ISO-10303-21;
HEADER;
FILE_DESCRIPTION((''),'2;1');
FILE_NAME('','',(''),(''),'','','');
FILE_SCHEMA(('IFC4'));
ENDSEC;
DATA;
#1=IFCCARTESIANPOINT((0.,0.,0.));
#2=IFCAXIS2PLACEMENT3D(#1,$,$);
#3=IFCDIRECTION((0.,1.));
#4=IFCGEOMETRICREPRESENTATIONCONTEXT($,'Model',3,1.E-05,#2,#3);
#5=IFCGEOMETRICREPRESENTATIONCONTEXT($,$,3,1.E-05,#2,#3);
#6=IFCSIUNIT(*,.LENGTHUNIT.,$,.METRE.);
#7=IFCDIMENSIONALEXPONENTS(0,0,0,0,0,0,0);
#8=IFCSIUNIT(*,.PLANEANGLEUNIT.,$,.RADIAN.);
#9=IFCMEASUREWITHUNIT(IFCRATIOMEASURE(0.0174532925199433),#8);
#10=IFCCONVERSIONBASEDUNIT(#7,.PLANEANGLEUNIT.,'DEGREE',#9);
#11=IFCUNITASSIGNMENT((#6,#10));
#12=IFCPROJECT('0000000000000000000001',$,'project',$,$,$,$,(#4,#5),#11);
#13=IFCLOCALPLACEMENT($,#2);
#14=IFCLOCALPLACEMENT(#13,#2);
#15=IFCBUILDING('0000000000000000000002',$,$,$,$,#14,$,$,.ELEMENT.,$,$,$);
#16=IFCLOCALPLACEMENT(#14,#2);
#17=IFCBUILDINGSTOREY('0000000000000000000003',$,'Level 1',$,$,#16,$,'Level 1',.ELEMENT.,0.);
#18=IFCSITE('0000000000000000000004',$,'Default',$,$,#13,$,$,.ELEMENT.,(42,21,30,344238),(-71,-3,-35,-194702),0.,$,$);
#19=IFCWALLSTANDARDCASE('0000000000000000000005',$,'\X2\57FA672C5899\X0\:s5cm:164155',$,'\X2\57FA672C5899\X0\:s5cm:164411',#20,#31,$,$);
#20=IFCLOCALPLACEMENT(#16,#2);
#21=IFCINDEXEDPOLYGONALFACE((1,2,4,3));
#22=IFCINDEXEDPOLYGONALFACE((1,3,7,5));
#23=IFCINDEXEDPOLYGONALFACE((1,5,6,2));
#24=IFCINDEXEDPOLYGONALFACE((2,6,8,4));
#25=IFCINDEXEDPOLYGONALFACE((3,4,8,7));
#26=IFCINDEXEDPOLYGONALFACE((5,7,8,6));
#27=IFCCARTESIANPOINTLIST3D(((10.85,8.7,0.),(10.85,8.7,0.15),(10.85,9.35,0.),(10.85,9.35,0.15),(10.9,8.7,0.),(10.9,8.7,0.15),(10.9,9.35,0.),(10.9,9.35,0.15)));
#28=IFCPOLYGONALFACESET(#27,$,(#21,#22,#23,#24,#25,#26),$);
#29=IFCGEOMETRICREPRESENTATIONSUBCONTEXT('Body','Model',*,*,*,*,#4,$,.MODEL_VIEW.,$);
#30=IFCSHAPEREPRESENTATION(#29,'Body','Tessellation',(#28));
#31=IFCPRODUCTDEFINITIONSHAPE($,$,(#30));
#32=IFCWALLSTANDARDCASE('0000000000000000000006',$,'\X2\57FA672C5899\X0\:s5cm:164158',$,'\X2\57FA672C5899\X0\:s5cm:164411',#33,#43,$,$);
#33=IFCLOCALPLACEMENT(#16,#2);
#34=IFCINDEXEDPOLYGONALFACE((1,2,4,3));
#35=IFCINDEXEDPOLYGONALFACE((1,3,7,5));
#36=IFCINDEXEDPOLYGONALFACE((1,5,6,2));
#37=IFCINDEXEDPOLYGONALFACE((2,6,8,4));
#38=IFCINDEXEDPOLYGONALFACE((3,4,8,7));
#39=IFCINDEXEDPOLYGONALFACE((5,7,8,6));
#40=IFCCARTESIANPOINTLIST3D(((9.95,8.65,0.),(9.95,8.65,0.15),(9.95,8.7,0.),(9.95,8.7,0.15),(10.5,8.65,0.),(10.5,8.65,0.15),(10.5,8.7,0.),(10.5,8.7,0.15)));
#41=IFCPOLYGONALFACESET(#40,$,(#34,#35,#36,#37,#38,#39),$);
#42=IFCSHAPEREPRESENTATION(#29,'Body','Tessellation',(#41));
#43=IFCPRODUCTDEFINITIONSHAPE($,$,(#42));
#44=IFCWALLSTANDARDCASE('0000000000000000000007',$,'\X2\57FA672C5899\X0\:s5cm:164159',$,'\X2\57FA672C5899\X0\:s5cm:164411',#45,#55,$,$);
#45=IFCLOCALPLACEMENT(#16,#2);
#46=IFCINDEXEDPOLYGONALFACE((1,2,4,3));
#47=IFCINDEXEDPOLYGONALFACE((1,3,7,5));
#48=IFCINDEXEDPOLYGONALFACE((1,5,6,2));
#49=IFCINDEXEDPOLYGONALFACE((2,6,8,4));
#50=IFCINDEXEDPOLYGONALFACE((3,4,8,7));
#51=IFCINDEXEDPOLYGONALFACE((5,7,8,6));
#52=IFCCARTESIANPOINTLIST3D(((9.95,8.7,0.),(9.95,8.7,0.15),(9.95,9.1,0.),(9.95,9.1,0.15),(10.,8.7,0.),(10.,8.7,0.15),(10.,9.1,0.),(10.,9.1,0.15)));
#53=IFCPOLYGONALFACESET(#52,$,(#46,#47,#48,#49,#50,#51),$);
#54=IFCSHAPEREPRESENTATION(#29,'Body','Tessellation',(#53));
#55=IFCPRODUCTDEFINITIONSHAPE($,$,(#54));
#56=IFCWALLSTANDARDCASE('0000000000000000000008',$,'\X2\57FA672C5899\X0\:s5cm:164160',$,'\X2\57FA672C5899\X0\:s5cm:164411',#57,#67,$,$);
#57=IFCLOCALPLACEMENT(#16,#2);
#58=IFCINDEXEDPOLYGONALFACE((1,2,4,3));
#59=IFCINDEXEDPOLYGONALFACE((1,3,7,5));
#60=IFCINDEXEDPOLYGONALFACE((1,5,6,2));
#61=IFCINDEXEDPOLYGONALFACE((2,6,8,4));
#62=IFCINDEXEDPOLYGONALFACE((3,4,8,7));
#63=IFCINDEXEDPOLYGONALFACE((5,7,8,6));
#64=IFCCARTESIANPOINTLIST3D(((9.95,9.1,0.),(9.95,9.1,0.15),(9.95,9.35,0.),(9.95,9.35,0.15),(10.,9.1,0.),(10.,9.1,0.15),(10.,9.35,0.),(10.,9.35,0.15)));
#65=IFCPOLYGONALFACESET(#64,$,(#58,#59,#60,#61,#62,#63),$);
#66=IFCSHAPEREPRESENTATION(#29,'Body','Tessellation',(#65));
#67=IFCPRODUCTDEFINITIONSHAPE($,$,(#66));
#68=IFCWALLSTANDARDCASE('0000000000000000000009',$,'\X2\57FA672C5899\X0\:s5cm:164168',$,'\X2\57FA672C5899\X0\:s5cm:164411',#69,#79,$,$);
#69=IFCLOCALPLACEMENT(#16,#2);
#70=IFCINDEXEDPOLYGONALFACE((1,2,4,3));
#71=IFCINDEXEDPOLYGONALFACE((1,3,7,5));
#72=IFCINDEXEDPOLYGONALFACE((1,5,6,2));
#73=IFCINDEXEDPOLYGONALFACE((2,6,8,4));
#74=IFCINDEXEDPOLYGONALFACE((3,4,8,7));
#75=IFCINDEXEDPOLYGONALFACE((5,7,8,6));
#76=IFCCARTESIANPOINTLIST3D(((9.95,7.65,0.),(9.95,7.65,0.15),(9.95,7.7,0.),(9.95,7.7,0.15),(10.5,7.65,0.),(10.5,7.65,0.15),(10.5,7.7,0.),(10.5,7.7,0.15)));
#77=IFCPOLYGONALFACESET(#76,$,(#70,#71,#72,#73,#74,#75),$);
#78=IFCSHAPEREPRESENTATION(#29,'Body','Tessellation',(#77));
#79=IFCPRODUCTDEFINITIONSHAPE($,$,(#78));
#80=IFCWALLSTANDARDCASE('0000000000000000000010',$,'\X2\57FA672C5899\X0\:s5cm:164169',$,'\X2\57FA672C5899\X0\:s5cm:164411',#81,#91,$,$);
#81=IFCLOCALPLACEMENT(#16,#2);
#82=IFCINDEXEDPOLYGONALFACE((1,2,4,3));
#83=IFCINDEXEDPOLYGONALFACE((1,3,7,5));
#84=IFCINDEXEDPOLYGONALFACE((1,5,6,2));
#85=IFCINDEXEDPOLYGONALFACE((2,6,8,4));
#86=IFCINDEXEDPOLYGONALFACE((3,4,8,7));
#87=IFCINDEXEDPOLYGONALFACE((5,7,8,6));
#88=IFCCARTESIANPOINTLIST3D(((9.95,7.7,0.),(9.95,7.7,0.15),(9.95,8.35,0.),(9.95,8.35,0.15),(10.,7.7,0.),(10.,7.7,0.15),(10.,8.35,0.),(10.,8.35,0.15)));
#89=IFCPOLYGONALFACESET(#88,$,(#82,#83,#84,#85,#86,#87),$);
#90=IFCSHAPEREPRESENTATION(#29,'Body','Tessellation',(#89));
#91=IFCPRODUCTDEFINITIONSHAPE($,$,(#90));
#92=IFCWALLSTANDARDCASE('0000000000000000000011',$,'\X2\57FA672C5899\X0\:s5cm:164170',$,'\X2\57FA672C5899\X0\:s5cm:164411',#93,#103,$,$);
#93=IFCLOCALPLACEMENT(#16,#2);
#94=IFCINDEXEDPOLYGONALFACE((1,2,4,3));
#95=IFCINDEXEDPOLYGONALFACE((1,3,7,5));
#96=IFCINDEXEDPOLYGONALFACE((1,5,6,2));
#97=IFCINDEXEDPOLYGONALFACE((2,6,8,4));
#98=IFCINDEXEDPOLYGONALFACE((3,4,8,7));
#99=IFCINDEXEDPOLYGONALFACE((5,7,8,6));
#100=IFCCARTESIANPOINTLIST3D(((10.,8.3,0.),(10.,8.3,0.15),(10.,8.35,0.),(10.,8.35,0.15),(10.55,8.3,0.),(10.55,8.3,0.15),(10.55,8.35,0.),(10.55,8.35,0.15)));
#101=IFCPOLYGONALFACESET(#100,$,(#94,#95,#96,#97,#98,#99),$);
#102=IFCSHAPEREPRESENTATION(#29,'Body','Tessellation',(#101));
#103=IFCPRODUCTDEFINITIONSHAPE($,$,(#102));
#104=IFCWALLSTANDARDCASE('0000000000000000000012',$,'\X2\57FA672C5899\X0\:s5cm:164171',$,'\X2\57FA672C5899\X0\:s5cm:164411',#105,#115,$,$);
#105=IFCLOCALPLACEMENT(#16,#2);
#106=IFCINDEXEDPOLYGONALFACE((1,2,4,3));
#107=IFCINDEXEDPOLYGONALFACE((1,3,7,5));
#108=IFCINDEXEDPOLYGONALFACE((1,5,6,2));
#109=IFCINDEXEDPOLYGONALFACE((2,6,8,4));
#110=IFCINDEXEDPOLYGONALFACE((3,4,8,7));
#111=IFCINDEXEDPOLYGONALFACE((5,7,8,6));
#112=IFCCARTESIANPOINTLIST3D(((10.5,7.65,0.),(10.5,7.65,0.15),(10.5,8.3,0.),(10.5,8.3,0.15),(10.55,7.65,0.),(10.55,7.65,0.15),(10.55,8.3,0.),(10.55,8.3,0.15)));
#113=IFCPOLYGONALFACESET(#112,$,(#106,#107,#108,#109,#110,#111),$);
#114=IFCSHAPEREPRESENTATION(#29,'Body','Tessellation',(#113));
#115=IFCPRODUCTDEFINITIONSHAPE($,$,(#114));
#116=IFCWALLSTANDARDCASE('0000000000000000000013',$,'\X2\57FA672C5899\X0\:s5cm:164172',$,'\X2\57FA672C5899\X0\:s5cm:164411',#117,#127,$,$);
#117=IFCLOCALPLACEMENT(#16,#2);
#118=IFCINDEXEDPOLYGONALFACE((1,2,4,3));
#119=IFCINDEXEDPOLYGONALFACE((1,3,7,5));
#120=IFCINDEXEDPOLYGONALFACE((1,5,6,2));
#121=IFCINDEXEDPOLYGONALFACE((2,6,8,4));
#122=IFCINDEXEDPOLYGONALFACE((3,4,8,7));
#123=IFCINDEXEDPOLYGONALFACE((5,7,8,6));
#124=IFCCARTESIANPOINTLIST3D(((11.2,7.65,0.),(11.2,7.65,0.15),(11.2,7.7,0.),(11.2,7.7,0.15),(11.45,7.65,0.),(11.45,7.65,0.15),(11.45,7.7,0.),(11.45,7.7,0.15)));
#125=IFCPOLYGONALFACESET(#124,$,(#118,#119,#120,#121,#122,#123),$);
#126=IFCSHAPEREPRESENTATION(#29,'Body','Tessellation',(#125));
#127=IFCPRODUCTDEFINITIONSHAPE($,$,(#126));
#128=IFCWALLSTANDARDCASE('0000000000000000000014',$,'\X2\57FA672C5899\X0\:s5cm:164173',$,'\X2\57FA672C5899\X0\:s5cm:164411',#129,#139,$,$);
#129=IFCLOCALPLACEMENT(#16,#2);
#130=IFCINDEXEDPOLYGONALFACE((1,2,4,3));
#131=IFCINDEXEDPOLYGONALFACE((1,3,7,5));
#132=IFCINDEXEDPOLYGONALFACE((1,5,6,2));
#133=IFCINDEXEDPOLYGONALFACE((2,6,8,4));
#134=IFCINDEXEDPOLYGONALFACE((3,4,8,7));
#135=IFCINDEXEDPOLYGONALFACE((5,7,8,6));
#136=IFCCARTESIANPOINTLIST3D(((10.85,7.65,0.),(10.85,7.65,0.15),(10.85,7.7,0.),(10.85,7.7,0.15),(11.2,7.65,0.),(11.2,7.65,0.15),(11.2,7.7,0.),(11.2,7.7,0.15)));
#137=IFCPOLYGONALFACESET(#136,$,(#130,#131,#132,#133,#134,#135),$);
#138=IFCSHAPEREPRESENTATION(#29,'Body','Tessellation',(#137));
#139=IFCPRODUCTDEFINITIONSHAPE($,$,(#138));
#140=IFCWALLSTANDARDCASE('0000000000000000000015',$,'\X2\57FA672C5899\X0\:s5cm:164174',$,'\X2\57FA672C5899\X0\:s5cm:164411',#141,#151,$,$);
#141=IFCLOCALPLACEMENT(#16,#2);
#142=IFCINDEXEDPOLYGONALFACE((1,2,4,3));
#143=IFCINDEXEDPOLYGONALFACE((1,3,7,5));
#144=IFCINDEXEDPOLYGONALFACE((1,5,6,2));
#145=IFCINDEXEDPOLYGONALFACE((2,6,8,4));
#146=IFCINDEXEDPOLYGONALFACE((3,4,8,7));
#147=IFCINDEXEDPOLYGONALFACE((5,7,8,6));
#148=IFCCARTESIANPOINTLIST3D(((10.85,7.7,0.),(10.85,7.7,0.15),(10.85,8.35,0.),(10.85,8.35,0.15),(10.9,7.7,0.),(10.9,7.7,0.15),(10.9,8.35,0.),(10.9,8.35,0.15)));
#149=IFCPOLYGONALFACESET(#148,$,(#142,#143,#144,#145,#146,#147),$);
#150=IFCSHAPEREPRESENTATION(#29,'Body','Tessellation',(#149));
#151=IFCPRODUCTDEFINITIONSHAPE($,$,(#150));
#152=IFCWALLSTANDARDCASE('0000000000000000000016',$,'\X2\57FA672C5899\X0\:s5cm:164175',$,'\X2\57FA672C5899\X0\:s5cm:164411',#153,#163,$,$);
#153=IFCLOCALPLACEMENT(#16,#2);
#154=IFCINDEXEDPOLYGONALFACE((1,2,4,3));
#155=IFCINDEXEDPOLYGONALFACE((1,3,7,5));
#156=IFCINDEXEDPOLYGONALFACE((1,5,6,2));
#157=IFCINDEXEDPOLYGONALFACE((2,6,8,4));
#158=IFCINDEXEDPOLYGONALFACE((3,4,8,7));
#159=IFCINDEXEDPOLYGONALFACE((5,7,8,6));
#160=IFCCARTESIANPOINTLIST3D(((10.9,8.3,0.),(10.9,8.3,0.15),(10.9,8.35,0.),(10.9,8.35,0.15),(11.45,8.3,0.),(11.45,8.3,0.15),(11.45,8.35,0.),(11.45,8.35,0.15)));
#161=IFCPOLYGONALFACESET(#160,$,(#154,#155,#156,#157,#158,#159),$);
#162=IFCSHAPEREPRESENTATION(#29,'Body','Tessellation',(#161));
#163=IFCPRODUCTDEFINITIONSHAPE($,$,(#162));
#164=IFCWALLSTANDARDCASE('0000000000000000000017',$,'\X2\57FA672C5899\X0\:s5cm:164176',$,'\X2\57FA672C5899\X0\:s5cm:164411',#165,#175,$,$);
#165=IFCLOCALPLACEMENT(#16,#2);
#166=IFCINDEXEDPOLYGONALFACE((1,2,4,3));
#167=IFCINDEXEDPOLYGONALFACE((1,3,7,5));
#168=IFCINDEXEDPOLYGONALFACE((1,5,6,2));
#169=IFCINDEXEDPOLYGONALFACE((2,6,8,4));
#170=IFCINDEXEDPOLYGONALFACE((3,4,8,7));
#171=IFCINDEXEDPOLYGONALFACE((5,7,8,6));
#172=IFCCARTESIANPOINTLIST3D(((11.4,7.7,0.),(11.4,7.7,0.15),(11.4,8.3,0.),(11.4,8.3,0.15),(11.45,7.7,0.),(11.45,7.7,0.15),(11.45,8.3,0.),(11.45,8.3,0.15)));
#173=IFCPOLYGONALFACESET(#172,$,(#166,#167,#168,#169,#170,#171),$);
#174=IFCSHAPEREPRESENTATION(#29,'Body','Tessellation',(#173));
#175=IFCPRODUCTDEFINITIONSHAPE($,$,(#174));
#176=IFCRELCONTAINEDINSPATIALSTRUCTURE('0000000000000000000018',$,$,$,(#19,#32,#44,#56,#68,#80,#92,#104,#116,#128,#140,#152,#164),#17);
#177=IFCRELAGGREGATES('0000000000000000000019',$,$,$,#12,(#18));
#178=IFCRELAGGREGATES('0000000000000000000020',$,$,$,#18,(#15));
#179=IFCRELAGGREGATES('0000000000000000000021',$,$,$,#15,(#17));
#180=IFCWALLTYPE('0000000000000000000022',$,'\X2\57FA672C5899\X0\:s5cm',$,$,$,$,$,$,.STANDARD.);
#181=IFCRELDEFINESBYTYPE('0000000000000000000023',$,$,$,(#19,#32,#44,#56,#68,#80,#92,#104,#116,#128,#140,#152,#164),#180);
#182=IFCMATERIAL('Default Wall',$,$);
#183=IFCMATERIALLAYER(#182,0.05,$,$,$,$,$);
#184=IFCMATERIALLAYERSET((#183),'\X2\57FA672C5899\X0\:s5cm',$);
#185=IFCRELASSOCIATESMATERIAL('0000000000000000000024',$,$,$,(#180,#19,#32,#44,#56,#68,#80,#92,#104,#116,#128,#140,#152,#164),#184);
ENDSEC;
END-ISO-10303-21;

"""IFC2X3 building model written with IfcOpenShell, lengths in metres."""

from ifc_helpers import new_model, entity, si_unit, converted_unit, direction, frame, frame_2d, origin, place, context, subcontext, project, spatial, rectangle, extrude, material, layer, layer_set, layer_usage, type_object, element, save


model = new_model("IFC2X3")

# Units and contexts
model_context = context("Model", 3, precision=1e-05, world=origin(), true_north=direction((0.0, 1.0)))
context_of_model = context(None, 3, precision=1e-05, world=origin(), true_north=direction((0.0, 1.0)))
body_context = subcontext(model_context, "Body", "Model", "MODEL_VIEW")
ifc_project = project(units=[si_unit("LENGTHUNIT", "METRE"), converted_unit("PLANEANGLEUNIT", "DEGREE", entity("IfcRatioMeasure", 0.0174532925199433), si_unit("PLANEANGLEUNIT", "RADIAN"), dimensions=[0, 0, 0, 0, 0, 0, 0])], contexts=[model_context, context_of_model])

# Site, building, storey
site_placement = place(None, origin())
site = spatial("IfcSite", under=ifc_project, at=site_placement, Name="Default", CompositionType="ELEMENT", RefLatitude=(42, 21, 30, 344238), RefLongitude=(-71, -3, -35, -194702), RefElevation=0.0)
building_placement = place(site_placement, origin())
building = spatial("IfcBuilding", under=site, at=building_placement, CompositionType="ELEMENT")
storey_placement = place(building_placement, origin())
storey = spatial("IfcBuildingStorey", under=building, at=storey_placement, Name="Level 1", LongName="Level 1", CompositionType="ELEMENT", Elevation=0.0)

# Shared definitions
ifc_material_1 = material(Name="Default Wall")

# Walls
ifc_layer_1 = layer(ifc_material_1, 0.05)
ifc_layer_set_1 = layer_set([ifc_layer_1], Name="基本墙:s5cm")
wall_type_1 = type_object("IfcWallType", Name="基本墙:s5cm", PredefinedType="STANDARD", material=ifc_layer_set_1)
ifc_layer_usage_1 = layer_usage(ifc_layer_set_1, "AXIS2", "NEGATIVE", 0.025)
wall_1_placement = place(storey_placement, frame((10.875, 8.7, 0.0), z_axis=(0.0, 0.0, 1.0), x_axis=(0.0, 1.0, 0.0)))
element("IfcWallStandardCase", 1, at=wall_1_placement, inside=storey, type_object=wall_type_1, material=ifc_layer_usage_1, Name="基本墙:s5cm:164155", ObjectType="基本墙:s5cm:164411", context=body_context, shape_type="SweptSolid", body=[
    extrude(rectangle(XDim=0.65, YDim=0.05, at=frame_2d((0.325, 0.0), x_axis=(-1.0, 0.0))), origin(), (0.0, 0.0, 1.0), 0.15),
])
ifc_layer_usage_2 = layer_usage(ifc_layer_set_1, "AXIS2", "NEGATIVE", 0.025)
wall_2_placement = place(storey_placement, frame((10.5, 8.675, 0.0), z_axis=(0.0, 0.0, 1.0), x_axis=(-1.0, 0.0, 0.0)))
element("IfcWallStandardCase", 2, at=wall_2_placement, inside=storey, type_object=wall_type_1, material=ifc_layer_usage_2, Name="基本墙:s5cm:164158", ObjectType="基本墙:s5cm:164411", context=body_context, shape_type="SweptSolid", body=[
    extrude(rectangle(XDim=0.55, YDim=0.05, at=frame_2d((0.275, 0.0), x_axis=(-1.0, 0.0))), origin(), (0.0, 0.0, 1.0), 0.15),
])
ifc_layer_usage_3 = layer_usage(ifc_layer_set_1, "AXIS2", "NEGATIVE", 0.025)
wall_3_placement = place(storey_placement, frame((9.975, 8.7, 0.0), z_axis=(0.0, 0.0, 1.0), x_axis=(0.0, 1.0, 0.0)))
element("IfcWallStandardCase", 3, at=wall_3_placement, inside=storey, type_object=wall_type_1, material=ifc_layer_usage_3, Name="基本墙:s5cm:164159", ObjectType="基本墙:s5cm:164411", context=body_context, shape_type="SweptSolid", body=[
    extrude(rectangle(XDim=0.4, YDim=0.05, at=frame_2d((0.2, 0.0), x_axis=(-1.0, 0.0))), origin(), (0.0, 0.0, 1.0), 0.15),
])
ifc_layer_usage_4 = layer_usage(ifc_layer_set_1, "AXIS2", "NEGATIVE", 0.025)
wall_4_placement = place(storey_placement, frame((9.975, 9.1, 0.0), z_axis=(0.0, 0.0, 1.0), x_axis=(0.0, 1.0, 0.0)))
element("IfcWallStandardCase", 4, at=wall_4_placement, inside=storey, type_object=wall_type_1, material=ifc_layer_usage_4, Name="基本墙:s5cm:164160", ObjectType="基本墙:s5cm:164411", context=body_context, shape_type="SweptSolid", body=[
    extrude(rectangle(XDim=0.25, YDim=0.05, at=frame_2d((0.125, 0.0), x_axis=(-1.0, 0.0))), origin(), (0.0, 0.0, 1.0), 0.15),
])
ifc_layer_usage_5 = layer_usage(ifc_layer_set_1, "AXIS2", "NEGATIVE", 0.025)
wall_5_placement = place(storey_placement, frame((10.5, 7.675, 0.0), z_axis=(0.0, 0.0, 1.0), x_axis=(-1.0, 0.0, 0.0)))
element("IfcWallStandardCase", 5, at=wall_5_placement, inside=storey, type_object=wall_type_1, material=ifc_layer_usage_5, Name="基本墙:s5cm:164168", ObjectType="基本墙:s5cm:164411", context=body_context, shape_type="SweptSolid", body=[
    extrude(rectangle(XDim=0.55, YDim=0.05, at=frame_2d((0.275, 0.0), x_axis=(-1.0, 0.0))), origin(), (0.0, 0.0, 1.0), 0.15),
])
ifc_layer_usage_6 = layer_usage(ifc_layer_set_1, "AXIS2", "NEGATIVE", 0.025)
wall_6_placement = place(storey_placement, frame((9.975, 7.7, 0.0), z_axis=(0.0, 0.0, 1.0), x_axis=(0.0, 1.0, 0.0)))
element("IfcWallStandardCase", 6, at=wall_6_placement, inside=storey, type_object=wall_type_1, material=ifc_layer_usage_6, Name="基本墙:s5cm:164169", ObjectType="基本墙:s5cm:164411", context=body_context, shape_type="SweptSolid", body=[
    extrude(rectangle(XDim=0.65, YDim=0.05, at=frame_2d((0.325, 0.0), x_axis=(-1.0, 0.0))), origin(), (0.0, 0.0, 1.0), 0.15),
])
ifc_layer_usage_7 = layer_usage(ifc_layer_set_1, "AXIS2", "NEGATIVE", 0.025)
wall_7_placement = place(storey_placement, frame((10.0, 8.325, 0.0)))
element("IfcWallStandardCase", 7, at=wall_7_placement, inside=storey, type_object=wall_type_1, material=ifc_layer_usage_7, Name="基本墙:s5cm:164170", ObjectType="基本墙:s5cm:164411", context=body_context, shape_type="SweptSolid", body=[
    extrude(rectangle(XDim=0.55, YDim=0.05, at=frame_2d((0.275, 0.0), x_axis=(-1.0, 0.0))), origin(), (0.0, 0.0, 1.0), 0.15),
])
ifc_layer_usage_8 = layer_usage(ifc_layer_set_1, "AXIS2", "NEGATIVE", 0.025)
wall_8_placement = place(storey_placement, frame((10.525, 8.3, 0.0), z_axis=(0.0, 0.0, 1.0), x_axis=(0.0, -1.0, 0.0)))
element("IfcWallStandardCase", 8, at=wall_8_placement, inside=storey, type_object=wall_type_1, material=ifc_layer_usage_8, Name="基本墙:s5cm:164171", ObjectType="基本墙:s5cm:164411", context=body_context, shape_type="SweptSolid", body=[
    extrude(rectangle(XDim=0.65, YDim=0.05, at=frame_2d((0.325, 0.0), x_axis=(-1.0, 0.0))), origin(), (0.0, 0.0, 1.0), 0.15),
])
ifc_layer_usage_9 = layer_usage(ifc_layer_set_1, "AXIS2", "NEGATIVE", 0.025)
wall_9_placement = place(storey_placement, frame((11.45, 7.675, 0.0), z_axis=(0.0, 0.0, 1.0), x_axis=(-1.0, 0.0, 0.0)))
element("IfcWallStandardCase", 9, at=wall_9_placement, inside=storey, type_object=wall_type_1, material=ifc_layer_usage_9, Name="基本墙:s5cm:164172", ObjectType="基本墙:s5cm:164411", context=body_context, shape_type="SweptSolid", body=[
    extrude(rectangle(XDim=0.25, YDim=0.05, at=frame_2d((0.125, 0.0), x_axis=(-1.0, 0.0))), origin(), (0.0, 0.0, 1.0), 0.15),
])
ifc_layer_usage_10 = layer_usage(ifc_layer_set_1, "AXIS2", "NEGATIVE", 0.025)
wall_10_placement = place(storey_placement, frame((11.2, 7.675, 0.0), z_axis=(0.0, 0.0, 1.0), x_axis=(-1.0, 0.0, 0.0)))
element("IfcWallStandardCase", 10, at=wall_10_placement, inside=storey, type_object=wall_type_1, material=ifc_layer_usage_10, Name="基本墙:s5cm:164173", ObjectType="基本墙:s5cm:164411", context=body_context, shape_type="SweptSolid", body=[
    extrude(rectangle(XDim=0.35, YDim=0.05, at=frame_2d((0.175, 0.0), x_axis=(-1.0, 0.0))), origin(), (0.0, 0.0, 1.0), 0.15),
])
ifc_layer_usage_11 = layer_usage(ifc_layer_set_1, "AXIS2", "NEGATIVE", 0.025)
wall_11_placement = place(storey_placement, frame((10.875, 7.7, 0.0), z_axis=(0.0, 0.0, 1.0), x_axis=(0.0, 1.0, 0.0)))
element("IfcWallStandardCase", 11, at=wall_11_placement, inside=storey, type_object=wall_type_1, material=ifc_layer_usage_11, Name="基本墙:s5cm:164174", ObjectType="基本墙:s5cm:164411", context=body_context, shape_type="SweptSolid", body=[
    extrude(rectangle(XDim=0.65, YDim=0.05, at=frame_2d((0.325, 0.0), x_axis=(-1.0, 0.0))), origin(), (0.0, 0.0, 1.0), 0.15),
])
ifc_layer_usage_12 = layer_usage(ifc_layer_set_1, "AXIS2", "NEGATIVE", 0.025)
wall_12_placement = place(storey_placement, frame((10.9, 8.325, 0.0)))
element("IfcWallStandardCase", 12, at=wall_12_placement, inside=storey, type_object=wall_type_1, material=ifc_layer_usage_12, Name="基本墙:s5cm:164175", ObjectType="基本墙:s5cm:164411", context=body_context, shape_type="SweptSolid", body=[
    extrude(rectangle(XDim=0.55, YDim=0.05, at=frame_2d((0.275, 0.0), x_axis=(-1.0, 0.0))), origin(), (0.0, 0.0, 1.0), 0.15),
])
ifc_layer_usage_13 = layer_usage(ifc_layer_set_1, "AXIS2", "NEGATIVE", 0.025)
wall_13_placement = place(storey_placement, frame((11.425, 8.3, 0.0), z_axis=(0.0, 0.0, 1.0), x_axis=(0.0, -1.0, 0.0)))
element("IfcWallStandardCase", 13, at=wall_13_placement, inside=storey, type_object=wall_type_1, material=ifc_layer_usage_13, Name="基本墙:s5cm:164176", ObjectType="基本墙:s5cm:164411", context=body_context, shape_type="SweptSolid", body=[
    extrude(rectangle(XDim=0.6, YDim=0.05, at=frame_2d((0.3, 0.0), x_axis=(-1.0, 0.0))), origin(), (0.0, 0.0, 1.0), 0.15),
])

save(model, "model.ifc")
